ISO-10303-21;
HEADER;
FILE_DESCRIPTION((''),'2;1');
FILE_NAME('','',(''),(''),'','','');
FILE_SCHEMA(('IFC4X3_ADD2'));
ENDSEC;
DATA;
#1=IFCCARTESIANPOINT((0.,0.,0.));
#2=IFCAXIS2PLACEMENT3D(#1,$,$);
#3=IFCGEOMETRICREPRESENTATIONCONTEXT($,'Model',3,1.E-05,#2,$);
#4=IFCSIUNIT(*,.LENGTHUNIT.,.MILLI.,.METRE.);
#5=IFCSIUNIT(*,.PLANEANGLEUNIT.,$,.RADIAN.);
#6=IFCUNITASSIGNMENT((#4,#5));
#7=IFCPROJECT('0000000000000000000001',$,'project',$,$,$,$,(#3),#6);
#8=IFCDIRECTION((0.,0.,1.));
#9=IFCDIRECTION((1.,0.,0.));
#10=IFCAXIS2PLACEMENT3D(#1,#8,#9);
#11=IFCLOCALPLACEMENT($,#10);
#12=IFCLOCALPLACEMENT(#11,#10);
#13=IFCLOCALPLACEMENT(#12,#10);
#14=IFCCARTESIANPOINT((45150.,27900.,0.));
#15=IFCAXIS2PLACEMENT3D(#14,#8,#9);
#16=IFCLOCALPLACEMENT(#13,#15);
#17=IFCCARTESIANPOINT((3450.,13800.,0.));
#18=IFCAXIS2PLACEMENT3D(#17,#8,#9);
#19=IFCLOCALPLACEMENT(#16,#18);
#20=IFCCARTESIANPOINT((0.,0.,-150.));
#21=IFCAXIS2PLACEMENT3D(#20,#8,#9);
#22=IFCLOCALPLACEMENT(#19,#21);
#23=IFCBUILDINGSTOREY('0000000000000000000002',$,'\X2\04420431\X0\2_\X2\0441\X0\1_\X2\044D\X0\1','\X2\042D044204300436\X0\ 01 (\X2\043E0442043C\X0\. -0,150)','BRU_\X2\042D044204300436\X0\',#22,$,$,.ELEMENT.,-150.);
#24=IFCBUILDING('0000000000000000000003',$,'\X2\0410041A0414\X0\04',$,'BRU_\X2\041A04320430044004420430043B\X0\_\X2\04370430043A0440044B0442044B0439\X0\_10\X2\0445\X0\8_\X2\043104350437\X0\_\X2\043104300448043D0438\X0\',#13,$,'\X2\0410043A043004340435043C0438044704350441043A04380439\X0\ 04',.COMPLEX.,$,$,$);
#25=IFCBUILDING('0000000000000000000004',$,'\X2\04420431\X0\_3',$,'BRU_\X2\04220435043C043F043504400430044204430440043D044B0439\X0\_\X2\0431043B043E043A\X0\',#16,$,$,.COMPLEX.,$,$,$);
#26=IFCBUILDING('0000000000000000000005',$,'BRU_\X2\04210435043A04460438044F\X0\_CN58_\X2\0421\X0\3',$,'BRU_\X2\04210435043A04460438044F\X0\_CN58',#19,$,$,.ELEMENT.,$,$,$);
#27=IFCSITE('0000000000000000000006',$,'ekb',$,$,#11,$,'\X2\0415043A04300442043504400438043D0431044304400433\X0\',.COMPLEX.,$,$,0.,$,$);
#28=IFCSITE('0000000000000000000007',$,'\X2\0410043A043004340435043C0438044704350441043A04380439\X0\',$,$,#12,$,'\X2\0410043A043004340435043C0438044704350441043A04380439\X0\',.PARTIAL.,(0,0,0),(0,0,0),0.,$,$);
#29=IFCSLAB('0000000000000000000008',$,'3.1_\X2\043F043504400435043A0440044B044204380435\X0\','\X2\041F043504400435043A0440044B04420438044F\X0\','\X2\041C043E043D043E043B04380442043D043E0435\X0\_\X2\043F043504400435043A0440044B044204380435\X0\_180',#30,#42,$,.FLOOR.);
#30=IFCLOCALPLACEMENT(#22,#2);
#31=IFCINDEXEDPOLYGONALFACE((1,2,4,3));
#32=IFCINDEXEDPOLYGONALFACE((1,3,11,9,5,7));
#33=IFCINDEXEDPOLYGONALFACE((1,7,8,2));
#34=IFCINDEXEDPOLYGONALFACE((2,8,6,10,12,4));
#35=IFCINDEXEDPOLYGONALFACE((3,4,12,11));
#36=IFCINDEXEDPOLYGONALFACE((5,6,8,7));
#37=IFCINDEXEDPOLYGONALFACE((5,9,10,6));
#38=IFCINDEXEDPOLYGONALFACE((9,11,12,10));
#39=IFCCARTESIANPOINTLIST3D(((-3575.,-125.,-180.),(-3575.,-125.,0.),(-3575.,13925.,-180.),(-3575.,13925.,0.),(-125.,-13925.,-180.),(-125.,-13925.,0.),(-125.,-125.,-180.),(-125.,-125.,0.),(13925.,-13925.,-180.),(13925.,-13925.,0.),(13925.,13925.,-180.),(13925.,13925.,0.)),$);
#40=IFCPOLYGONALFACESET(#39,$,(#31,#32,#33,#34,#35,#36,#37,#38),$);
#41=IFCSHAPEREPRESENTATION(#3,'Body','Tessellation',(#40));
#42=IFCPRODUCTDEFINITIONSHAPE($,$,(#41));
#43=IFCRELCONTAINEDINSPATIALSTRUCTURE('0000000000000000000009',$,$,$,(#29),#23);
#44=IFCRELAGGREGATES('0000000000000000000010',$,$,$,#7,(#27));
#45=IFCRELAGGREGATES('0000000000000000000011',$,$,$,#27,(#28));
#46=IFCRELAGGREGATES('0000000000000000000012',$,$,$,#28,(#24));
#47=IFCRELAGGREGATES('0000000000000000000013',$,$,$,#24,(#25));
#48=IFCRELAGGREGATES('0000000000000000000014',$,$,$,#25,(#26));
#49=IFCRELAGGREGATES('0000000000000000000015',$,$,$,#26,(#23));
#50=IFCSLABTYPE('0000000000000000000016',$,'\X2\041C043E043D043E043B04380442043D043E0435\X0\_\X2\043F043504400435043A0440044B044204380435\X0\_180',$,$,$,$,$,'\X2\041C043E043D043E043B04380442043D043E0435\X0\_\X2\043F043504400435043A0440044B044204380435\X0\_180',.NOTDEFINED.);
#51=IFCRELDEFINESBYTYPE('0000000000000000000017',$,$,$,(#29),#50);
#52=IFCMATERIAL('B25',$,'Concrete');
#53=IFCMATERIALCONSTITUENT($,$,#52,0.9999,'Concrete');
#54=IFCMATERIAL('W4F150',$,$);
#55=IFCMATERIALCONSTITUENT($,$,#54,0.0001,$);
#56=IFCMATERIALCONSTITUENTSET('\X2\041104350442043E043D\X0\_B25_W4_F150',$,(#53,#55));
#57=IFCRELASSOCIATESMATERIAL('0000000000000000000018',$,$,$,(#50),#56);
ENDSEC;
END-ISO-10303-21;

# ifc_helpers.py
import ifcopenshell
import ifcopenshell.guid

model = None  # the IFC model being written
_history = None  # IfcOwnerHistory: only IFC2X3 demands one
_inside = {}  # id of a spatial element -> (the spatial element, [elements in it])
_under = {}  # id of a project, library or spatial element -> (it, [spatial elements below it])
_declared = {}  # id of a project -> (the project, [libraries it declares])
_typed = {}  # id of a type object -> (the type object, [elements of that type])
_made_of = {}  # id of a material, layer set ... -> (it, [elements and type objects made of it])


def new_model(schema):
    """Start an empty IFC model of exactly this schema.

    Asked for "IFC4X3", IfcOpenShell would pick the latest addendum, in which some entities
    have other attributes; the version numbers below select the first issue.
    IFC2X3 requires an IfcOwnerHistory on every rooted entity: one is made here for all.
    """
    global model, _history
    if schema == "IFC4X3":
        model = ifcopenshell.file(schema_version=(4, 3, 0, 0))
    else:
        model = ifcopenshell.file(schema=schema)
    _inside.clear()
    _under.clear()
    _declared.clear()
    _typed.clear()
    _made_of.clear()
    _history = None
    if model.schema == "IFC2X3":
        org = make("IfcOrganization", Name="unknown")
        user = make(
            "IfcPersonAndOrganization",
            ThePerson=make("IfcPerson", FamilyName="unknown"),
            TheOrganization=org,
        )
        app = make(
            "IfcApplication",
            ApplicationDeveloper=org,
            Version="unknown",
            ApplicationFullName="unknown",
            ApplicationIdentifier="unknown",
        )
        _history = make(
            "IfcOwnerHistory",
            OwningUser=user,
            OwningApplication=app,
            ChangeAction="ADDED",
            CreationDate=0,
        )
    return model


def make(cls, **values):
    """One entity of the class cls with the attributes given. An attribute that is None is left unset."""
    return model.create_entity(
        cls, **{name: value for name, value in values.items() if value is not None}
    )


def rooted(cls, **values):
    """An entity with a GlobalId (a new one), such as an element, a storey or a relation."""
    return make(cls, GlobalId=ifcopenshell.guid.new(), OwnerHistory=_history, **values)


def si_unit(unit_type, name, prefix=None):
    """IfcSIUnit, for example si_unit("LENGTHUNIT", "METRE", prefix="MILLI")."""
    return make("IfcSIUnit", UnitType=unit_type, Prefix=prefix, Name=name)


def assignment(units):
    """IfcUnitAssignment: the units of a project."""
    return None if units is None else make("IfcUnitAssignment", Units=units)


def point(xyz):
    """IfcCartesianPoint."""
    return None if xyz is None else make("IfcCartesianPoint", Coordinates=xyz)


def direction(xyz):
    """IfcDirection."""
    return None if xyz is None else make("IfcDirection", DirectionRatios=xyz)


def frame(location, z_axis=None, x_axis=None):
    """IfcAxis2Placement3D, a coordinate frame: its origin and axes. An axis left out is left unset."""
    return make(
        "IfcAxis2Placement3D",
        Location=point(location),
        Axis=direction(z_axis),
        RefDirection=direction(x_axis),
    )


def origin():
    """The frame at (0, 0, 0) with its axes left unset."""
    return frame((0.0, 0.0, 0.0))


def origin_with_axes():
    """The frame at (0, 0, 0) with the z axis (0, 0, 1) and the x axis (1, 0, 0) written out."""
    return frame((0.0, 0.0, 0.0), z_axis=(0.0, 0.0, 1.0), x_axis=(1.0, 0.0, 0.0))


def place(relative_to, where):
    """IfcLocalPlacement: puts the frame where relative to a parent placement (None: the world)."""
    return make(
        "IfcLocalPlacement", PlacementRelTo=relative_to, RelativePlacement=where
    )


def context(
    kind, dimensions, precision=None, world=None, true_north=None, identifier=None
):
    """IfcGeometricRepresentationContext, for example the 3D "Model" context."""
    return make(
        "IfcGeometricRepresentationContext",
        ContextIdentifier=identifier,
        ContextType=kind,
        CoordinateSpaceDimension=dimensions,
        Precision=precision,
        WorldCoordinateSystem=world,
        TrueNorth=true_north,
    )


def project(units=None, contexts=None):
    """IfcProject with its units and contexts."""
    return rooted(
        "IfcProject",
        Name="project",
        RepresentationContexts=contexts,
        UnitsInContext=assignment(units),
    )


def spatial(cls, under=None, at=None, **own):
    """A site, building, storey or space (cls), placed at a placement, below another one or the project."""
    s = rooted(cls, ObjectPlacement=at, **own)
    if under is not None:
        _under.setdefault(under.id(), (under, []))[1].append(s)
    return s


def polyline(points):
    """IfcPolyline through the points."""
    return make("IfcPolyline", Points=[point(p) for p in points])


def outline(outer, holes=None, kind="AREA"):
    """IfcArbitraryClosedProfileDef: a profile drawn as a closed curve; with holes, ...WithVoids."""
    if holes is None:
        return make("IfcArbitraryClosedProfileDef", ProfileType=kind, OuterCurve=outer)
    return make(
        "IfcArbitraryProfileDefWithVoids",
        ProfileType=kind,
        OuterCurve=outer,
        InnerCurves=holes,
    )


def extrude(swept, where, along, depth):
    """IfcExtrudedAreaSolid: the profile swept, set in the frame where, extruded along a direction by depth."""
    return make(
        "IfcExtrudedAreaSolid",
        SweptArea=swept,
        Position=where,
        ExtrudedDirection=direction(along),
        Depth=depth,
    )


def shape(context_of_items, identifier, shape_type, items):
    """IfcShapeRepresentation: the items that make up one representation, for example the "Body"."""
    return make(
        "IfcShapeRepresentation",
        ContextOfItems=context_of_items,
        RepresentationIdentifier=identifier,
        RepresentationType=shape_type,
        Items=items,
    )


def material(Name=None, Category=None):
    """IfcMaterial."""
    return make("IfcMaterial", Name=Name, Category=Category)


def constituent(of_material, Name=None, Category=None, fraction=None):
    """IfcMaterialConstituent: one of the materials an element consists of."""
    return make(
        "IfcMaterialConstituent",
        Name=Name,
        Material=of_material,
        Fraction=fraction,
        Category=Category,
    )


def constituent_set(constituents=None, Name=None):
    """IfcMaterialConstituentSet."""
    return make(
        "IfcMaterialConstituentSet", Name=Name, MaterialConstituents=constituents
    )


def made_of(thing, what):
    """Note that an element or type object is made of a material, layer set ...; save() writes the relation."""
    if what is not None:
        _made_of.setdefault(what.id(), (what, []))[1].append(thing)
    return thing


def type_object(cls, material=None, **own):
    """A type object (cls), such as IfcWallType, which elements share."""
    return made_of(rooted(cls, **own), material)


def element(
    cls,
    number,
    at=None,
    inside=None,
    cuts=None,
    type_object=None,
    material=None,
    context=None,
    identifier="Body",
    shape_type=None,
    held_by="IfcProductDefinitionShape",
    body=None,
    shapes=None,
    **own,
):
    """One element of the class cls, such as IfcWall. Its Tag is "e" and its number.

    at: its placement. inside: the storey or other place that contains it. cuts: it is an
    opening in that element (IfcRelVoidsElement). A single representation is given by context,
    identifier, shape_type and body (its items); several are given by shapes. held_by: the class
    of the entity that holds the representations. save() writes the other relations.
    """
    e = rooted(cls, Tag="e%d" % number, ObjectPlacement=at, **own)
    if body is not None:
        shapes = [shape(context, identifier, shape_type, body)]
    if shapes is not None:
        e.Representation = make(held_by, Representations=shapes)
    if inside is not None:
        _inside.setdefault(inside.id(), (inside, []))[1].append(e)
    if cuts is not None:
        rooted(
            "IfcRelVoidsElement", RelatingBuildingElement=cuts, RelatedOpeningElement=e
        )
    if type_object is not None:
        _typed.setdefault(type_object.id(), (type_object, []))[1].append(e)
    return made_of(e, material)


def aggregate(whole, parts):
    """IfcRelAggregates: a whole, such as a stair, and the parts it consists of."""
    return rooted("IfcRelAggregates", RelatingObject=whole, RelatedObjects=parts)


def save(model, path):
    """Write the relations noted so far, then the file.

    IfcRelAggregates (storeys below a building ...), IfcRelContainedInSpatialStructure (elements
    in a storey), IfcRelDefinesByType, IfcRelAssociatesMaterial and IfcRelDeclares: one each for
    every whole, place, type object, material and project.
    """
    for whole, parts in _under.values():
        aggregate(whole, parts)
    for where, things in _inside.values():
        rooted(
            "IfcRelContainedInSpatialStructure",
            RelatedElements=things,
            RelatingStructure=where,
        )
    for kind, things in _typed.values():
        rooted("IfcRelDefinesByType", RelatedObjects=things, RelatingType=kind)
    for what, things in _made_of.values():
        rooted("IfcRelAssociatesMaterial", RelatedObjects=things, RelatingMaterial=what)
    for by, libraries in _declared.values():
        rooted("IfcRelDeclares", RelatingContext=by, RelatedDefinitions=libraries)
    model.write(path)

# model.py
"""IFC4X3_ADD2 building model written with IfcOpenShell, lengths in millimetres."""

from ifc_helpers import new_model, si_unit, frame, origin, origin_with_axes, place, context, project, spatial, polyline, outline, extrude, material, constituent, constituent_set, type_object, element, save


model = new_model("IFC4X3_ADD2")

# Units and contexts
model_context = context("Model", 3, precision=1e-05, world=origin())
ifc_project = project(units=[si_unit("LENGTHUNIT", "METRE", prefix="MILLI"), si_unit("PLANEANGLEUNIT", "RADIAN")], contexts=[model_context])

# Sites, buildings, storey
site_1_placement = place(None, origin_with_axes())
site_1 = spatial("IfcSite", under=ifc_project, at=site_1_placement, Name="ekb", LongName="Екатеринбург", CompositionType="COMPLEX", RefElevation=0.0)
site_2_placement = place(site_1_placement, origin_with_axes())
site_2 = spatial("IfcSite", under=site_1, at=site_2_placement, Name="Академический", LongName="Академический", CompositionType="PARTIAL", RefLatitude=(0, 0, 0), RefLongitude=(0, 0, 0), RefElevation=0.0)
building_1_placement = place(site_2_placement, origin_with_axes())
building_1 = spatial("IfcBuilding", under=site_2, at=building_1_placement, Name="АКД04", ObjectType="BRU_Квартал_закрытый_10х8_без_башни", LongName="Академический 04", CompositionType="COMPLEX")
building_2_placement = place(building_1_placement, frame((45150.0, 27900.0, 0.0), z_axis=(0.0, 0.0, 1.0), x_axis=(1.0, 0.0, 0.0)))
building_2 = spatial("IfcBuilding", under=building_1, at=building_2_placement, Name="тб_3", ObjectType="BRU_Температурный_блок", CompositionType="COMPLEX")
building_3_placement = place(building_2_placement, frame((3450.0, 13800.0, 0.0), z_axis=(0.0, 0.0, 1.0), x_axis=(1.0, 0.0, 0.0)))
building_3 = spatial("IfcBuilding", under=building_2, at=building_3_placement, Name="BRU_Секция_CN58_С3", ObjectType="BRU_Секция_CN58", CompositionType="ELEMENT")
storey_placement = place(building_3_placement, frame((0.0, 0.0, -150.0), z_axis=(0.0, 0.0, 1.0), x_axis=(1.0, 0.0, 0.0)))
storey = spatial("IfcBuildingStorey", under=building_3, at=storey_placement, Name="тб2_с1_э1", Description="Этаж 01 (отм. -0,150)", ObjectType="BRU_Этаж", CompositionType="ELEMENT", Elevation=-150.0)

# Shared definitions
ifc_material_1 = material(Name="B25", Category="Concrete")
ifc_material_2 = material(Name="W4F150")

# Slab
ifc_constituent_1 = constituent(ifc_material_1, Category="Concrete", fraction=0.9999)
ifc_constituent_2 = constituent(ifc_material_2, fraction=0.0001)
ifc_constituent_set_1 = constituent_set(constituents=[ifc_constituent_1, ifc_constituent_2], Name="Бетон_B25_W4_F150")
slab_type = type_object("IfcSlabType", Name="Монолитное_перекрытие_180", ElementType="Монолитное_перекрытие_180", PredefinedType="NOTDEFINED", material=ifc_constituent_set_1)
slab_placement = place(storey_placement, frame((0.0, 0.0, -180.0), z_axis=(0.0, 0.0, 1.0), x_axis=(1.0, 0.0, 0.0)))
element("IfcSlab", 1, at=slab_placement, inside=storey, type_object=slab_type, Name="3.1_перекрытие", Description="Перекрытия", ObjectType="Монолитное_перекрытие_180", PredefinedType="FLOOR", context=model_context, shape_type="SweptSolid", body=[
    extrude(outline(polyline([(-125.0, -13925.0), (13925.0, -13925.0), (13925.0, 13925.0), (-3575.0, 13925.0), (-3575.0, -125.0), (-125.0, -125.0), (-125.0, -13925.0)])), origin_with_axes(), (0.0, 0.0, 1.0), 180.0),
])

save(model, "model.ifc")
